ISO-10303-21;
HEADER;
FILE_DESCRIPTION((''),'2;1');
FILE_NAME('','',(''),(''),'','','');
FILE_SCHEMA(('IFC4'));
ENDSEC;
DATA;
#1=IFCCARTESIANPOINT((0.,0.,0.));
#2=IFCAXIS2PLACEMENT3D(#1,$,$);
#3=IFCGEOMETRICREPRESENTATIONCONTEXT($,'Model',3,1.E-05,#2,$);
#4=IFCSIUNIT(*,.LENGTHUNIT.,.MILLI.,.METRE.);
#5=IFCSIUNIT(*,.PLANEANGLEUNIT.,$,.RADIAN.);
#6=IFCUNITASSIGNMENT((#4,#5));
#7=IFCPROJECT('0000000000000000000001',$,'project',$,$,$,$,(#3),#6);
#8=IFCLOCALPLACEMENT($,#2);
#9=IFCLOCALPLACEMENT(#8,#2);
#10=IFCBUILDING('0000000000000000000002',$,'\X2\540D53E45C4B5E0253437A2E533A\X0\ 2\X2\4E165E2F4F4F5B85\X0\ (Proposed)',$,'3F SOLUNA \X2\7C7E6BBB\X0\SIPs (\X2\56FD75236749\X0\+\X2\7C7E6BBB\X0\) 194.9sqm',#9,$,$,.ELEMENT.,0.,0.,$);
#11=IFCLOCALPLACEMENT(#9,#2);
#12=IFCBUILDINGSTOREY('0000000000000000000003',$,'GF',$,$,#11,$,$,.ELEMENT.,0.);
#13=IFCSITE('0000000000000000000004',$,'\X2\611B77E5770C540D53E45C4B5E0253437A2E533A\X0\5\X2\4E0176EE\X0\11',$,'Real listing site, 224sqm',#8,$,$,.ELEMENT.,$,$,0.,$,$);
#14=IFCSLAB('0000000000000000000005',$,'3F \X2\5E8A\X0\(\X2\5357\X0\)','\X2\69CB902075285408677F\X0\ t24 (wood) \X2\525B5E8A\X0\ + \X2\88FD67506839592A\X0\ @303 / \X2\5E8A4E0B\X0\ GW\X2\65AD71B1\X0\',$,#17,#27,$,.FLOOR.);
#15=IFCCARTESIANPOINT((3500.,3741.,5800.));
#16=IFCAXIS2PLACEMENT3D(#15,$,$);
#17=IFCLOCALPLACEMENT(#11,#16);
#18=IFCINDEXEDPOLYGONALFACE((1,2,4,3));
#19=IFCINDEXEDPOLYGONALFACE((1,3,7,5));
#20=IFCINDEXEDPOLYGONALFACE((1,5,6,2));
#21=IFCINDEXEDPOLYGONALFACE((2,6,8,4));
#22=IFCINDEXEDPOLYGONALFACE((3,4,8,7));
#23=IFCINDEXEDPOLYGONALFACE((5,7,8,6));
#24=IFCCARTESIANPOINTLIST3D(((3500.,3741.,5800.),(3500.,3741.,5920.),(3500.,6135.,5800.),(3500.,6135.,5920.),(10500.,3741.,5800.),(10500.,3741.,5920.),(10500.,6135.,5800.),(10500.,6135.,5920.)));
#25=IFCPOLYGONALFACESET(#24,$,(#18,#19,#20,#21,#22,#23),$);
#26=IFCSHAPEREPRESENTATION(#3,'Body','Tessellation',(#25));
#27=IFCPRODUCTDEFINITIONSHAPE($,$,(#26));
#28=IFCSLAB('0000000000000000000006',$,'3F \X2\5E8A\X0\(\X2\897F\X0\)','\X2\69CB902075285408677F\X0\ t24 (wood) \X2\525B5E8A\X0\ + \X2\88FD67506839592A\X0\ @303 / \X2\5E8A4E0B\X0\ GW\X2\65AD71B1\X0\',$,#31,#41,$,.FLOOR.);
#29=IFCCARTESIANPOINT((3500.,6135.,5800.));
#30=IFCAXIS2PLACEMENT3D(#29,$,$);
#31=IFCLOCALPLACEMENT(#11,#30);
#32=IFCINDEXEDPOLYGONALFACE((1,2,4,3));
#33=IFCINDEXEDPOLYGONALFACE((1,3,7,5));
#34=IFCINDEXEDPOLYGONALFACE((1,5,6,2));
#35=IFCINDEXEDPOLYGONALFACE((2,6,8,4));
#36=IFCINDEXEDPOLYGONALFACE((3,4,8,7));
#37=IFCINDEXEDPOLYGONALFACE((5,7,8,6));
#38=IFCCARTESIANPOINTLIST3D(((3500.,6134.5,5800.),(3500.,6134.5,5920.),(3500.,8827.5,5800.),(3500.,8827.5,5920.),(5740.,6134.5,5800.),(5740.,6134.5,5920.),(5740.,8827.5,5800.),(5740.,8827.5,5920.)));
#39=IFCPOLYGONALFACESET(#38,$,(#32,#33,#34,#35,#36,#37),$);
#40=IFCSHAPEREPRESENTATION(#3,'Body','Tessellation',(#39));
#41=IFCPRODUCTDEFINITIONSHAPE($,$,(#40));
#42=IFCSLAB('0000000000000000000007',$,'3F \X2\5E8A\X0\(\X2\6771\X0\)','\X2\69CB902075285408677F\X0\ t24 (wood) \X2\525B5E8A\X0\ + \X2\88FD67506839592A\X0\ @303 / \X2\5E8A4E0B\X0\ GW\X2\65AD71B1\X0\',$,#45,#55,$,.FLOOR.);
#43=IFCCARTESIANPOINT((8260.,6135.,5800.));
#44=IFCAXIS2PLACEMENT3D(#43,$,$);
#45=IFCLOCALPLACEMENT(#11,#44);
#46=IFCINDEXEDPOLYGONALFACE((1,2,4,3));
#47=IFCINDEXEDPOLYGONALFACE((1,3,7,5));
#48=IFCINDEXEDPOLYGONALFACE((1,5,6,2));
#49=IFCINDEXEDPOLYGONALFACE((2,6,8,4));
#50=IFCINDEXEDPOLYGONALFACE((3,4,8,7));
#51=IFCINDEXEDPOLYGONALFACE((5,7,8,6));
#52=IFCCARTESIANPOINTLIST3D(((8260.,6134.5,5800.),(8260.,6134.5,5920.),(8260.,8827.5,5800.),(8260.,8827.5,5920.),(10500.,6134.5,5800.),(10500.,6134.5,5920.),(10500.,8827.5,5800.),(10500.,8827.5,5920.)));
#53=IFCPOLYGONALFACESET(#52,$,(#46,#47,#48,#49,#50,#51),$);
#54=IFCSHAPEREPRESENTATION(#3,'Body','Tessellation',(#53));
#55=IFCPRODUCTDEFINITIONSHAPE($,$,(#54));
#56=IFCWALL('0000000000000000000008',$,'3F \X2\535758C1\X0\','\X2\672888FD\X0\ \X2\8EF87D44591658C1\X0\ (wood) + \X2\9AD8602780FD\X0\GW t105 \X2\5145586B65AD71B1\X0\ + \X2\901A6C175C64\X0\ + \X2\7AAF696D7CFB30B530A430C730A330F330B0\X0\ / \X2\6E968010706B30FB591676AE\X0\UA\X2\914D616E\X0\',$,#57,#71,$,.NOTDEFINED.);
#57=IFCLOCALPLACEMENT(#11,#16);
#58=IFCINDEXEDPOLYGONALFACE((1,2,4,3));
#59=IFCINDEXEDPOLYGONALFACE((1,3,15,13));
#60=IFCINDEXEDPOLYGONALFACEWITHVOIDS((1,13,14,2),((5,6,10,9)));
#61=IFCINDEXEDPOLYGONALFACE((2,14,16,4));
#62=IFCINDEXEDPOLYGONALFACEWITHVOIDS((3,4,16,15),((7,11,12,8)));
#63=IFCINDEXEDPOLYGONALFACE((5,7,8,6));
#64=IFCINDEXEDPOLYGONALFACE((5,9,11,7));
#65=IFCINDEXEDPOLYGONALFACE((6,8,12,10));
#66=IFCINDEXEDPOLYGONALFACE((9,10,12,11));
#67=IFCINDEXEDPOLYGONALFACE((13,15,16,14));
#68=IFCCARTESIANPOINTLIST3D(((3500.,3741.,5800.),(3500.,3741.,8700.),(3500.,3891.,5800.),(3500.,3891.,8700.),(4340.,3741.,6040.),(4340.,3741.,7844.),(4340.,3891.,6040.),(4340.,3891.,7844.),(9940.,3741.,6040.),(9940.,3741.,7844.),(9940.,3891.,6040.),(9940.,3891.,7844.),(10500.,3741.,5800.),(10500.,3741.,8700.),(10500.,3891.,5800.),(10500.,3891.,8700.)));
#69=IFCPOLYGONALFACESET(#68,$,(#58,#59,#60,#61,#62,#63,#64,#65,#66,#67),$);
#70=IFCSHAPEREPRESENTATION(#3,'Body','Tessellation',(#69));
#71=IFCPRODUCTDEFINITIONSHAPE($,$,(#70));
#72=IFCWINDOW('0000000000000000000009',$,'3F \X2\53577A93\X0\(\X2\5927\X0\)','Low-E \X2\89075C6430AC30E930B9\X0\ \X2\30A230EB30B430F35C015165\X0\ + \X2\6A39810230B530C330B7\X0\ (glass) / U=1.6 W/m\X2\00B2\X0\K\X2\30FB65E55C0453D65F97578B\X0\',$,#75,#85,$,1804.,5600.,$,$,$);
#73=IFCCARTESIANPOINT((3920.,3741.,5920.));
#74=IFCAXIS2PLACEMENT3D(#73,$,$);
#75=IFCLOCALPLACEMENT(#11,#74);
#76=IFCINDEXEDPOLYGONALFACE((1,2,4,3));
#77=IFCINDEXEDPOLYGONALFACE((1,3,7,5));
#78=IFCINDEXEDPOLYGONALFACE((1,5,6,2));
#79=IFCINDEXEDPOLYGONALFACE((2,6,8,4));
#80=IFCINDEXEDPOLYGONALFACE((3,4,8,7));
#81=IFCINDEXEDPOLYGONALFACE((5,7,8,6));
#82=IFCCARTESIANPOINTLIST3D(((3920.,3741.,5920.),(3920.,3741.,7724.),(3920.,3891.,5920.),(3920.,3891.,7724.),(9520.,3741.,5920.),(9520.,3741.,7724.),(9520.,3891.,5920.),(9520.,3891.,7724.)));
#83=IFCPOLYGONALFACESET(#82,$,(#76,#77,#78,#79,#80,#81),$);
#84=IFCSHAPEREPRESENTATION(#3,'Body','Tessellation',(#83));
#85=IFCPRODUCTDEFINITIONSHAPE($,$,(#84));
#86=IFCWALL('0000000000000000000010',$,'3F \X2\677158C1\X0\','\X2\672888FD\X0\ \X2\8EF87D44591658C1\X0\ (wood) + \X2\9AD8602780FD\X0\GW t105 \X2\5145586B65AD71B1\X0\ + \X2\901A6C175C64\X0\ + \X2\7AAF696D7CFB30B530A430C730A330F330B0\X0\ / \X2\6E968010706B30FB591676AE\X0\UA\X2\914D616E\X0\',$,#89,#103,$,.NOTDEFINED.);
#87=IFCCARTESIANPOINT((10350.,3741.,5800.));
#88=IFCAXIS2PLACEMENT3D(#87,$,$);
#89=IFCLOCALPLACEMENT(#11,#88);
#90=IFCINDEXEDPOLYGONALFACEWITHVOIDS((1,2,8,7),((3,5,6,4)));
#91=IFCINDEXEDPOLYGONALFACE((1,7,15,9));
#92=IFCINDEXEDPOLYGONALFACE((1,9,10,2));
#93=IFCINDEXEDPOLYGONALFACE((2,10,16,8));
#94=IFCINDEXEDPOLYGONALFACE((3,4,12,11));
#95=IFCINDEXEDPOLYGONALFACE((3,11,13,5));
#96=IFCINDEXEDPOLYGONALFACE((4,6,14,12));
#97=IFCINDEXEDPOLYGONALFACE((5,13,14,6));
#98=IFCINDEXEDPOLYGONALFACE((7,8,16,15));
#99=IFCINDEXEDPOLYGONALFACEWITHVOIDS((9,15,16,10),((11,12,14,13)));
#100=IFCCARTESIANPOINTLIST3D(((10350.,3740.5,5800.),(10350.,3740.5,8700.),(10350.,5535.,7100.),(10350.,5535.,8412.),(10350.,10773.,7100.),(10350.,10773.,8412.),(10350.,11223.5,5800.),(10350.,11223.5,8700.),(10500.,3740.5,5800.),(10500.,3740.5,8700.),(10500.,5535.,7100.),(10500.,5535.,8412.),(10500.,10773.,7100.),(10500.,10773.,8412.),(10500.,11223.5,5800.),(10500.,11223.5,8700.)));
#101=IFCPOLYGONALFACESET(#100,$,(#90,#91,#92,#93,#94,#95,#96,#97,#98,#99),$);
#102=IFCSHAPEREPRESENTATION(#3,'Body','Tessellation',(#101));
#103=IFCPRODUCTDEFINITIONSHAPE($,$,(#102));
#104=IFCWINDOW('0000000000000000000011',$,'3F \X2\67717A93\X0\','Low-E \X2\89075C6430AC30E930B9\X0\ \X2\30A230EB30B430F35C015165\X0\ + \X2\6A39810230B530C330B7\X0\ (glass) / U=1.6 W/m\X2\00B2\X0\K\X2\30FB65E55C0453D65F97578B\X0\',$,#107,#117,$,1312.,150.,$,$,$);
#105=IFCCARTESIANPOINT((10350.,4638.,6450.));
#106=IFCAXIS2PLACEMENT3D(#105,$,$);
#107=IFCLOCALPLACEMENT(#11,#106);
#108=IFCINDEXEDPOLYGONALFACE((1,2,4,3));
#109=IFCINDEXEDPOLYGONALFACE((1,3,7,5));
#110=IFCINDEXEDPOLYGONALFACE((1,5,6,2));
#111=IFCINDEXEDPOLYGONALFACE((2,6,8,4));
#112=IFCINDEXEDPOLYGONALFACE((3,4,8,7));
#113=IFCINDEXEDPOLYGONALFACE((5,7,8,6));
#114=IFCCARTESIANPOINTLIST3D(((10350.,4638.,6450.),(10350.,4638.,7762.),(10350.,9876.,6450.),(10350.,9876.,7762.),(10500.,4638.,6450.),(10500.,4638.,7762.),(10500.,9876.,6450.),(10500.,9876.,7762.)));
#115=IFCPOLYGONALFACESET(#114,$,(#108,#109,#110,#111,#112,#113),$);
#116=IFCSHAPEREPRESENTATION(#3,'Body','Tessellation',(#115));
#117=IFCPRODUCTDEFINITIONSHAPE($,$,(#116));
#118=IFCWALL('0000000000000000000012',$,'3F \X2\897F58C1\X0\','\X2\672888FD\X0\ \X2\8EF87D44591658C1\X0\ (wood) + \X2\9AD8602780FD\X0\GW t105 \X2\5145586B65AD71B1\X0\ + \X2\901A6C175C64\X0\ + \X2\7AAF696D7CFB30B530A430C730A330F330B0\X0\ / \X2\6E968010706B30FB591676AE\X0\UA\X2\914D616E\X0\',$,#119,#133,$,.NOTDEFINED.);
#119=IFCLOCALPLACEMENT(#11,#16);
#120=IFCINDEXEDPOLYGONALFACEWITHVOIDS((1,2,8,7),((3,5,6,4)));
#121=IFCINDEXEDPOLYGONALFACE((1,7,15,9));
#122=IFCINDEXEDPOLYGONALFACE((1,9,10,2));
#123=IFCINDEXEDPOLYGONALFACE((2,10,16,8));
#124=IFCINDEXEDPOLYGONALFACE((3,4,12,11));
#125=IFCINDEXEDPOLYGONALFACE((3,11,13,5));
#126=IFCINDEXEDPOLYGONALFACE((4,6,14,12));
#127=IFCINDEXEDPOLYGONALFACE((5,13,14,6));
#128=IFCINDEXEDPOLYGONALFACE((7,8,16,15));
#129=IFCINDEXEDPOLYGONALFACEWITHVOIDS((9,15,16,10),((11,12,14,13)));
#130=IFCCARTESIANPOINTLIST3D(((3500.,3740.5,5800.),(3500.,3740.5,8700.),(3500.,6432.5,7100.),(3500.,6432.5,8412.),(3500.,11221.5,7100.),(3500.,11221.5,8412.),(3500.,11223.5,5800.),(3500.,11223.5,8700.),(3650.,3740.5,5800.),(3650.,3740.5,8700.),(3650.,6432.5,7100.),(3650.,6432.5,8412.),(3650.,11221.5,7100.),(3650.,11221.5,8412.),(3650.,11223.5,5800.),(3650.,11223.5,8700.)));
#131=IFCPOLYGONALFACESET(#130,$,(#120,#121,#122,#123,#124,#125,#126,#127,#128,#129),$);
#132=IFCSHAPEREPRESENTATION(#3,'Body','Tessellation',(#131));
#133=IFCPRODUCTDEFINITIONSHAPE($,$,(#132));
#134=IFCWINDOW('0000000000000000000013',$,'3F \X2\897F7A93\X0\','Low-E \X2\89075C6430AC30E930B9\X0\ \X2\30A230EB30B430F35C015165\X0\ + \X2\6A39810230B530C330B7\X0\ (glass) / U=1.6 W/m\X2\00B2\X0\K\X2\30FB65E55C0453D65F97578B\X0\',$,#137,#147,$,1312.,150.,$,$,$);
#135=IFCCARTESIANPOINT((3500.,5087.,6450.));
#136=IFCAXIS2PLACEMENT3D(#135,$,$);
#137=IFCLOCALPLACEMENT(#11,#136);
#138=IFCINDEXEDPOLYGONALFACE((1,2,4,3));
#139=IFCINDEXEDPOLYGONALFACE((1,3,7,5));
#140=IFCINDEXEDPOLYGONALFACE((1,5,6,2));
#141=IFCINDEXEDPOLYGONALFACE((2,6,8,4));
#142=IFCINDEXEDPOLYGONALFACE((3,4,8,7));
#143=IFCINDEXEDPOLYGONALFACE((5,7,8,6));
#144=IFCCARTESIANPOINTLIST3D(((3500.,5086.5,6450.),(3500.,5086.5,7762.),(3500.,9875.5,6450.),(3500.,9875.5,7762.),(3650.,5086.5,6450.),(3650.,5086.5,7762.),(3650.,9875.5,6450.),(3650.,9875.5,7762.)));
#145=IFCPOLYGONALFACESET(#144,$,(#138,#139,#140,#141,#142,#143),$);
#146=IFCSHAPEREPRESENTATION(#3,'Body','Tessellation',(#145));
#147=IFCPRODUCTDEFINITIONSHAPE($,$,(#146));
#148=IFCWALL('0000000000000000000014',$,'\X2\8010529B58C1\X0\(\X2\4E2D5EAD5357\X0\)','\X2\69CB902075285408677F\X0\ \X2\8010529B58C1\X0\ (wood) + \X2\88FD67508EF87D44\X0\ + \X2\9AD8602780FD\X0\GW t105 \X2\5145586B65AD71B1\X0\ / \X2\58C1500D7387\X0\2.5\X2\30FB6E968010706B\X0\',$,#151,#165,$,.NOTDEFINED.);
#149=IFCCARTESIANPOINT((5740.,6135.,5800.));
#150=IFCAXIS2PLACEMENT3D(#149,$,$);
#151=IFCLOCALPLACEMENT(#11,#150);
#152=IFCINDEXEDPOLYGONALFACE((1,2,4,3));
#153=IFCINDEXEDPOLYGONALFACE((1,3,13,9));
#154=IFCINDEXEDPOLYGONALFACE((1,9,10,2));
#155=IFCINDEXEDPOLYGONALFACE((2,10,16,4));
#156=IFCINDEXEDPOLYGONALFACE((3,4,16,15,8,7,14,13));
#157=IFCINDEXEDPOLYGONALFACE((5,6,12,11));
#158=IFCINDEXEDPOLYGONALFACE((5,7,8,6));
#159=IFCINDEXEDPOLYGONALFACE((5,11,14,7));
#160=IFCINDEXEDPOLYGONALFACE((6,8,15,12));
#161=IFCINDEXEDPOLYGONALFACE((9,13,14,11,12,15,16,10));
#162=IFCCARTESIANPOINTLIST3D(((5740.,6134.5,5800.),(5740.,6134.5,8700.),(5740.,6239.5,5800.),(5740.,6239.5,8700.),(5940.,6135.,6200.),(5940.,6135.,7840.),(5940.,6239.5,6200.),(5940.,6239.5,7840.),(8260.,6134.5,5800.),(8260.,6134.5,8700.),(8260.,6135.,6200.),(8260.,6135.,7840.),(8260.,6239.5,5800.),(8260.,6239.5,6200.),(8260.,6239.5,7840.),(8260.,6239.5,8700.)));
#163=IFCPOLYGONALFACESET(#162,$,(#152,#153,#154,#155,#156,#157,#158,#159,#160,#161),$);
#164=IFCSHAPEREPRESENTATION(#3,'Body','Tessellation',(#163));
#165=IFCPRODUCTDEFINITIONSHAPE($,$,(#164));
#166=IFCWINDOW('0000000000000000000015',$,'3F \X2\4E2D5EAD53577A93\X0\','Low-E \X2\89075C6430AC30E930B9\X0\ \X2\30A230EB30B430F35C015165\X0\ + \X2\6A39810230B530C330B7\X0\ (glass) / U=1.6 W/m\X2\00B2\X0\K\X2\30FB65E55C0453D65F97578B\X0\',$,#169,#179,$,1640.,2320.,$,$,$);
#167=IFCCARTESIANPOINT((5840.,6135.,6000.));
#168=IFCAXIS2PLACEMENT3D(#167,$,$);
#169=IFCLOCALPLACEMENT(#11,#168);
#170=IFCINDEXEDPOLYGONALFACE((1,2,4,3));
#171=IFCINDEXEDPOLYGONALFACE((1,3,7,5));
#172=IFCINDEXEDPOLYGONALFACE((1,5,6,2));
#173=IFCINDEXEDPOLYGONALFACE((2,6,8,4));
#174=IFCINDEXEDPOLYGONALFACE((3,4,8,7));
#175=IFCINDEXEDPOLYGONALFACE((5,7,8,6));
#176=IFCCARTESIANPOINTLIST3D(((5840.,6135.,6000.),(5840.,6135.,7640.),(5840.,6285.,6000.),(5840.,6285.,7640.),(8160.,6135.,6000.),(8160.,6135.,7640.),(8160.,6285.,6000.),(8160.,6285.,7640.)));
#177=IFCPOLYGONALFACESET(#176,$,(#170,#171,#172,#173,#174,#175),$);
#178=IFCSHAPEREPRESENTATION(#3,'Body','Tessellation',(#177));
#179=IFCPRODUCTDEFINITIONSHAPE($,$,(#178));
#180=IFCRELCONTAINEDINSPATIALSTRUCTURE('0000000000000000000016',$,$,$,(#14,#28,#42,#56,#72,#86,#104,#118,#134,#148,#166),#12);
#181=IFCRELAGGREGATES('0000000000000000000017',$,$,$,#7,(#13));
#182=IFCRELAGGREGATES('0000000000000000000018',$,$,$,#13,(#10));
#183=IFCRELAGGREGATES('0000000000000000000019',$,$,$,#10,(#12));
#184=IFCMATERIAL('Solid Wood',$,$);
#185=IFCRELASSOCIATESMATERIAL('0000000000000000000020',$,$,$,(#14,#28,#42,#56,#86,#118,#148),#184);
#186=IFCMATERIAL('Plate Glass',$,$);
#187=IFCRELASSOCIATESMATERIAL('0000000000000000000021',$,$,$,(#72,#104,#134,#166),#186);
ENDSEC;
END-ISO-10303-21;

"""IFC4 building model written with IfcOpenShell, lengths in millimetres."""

from ifc_helpers import new_model, si_unit, frame, frame_2d, origin, place, context, project, spatial, rectangle, extrude, material, element, fill, save


model = new_model("IFC4")

# Units and contexts
model_context = context("Model", 3, precision=1e-05, world=origin())
ifc_project = project(units=[si_unit("LENGTHUNIT", "METRE", prefix="MILLI"), si_unit("PLANEANGLEUNIT", "RADIAN")], contexts=[model_context])

# Site, building, storey
site_placement = place(None, origin())
site = spatial("IfcSite", under=ifc_project, at=site_placement, Name="愛知県名古屋市千種区5丁目11", ObjectType="Real listing site, 224sqm", CompositionType="ELEMENT", RefElevation=0.0)
building_placement = place(site_placement, origin())
building = spatial("IfcBuilding", under=site, at=building_placement, Name="名古屋市千種区 2世帯住宅 (Proposed)", ObjectType="3F SOLUNA 籾殻SIPs (国産杉+籾殻) 194.9sqm", CompositionType="ELEMENT", ElevationOfRefHeight=0.0, ElevationOfTerrain=0.0)
storey_placement = place(building_placement, origin())
storey = spatial("IfcBuildingStorey", under=building, at=storey_placement, Name="GF", CompositionType="ELEMENT", Elevation=0.0)

# Slabs
ifc_material_1 = material(Name="Solid Wood")
slab_1_placement = place(storey_placement, frame((3500.0, 3741.0, 5800.0)))
element("IfcSlab", 1, at=slab_1_placement, inside=storey, material=ifc_material_1, Name="3F 床(南)", Description="構造用合板 t24 (wood) 剛床 + 製材根太 @303 / 床下 GW断熱", PredefinedType="FLOOR", context=model_context, shape_type="SweptSolid", body=[
    extrude(rectangle(XDim=7000.0, YDim=2394.0, at=frame_2d((3500.0, 1197.0))), frame((3500.0, 3741.0, 5800.0)), (0.0, 0.0, 1.0), 120.0),
])
slab_2_placement = place(storey_placement, frame((3500.0, 6135.0, 5800.0)))
element("IfcSlab", 2, at=slab_2_placement, inside=storey, material=ifc_material_1, Name="3F 床(西)", Description="構造用合板 t24 (wood) 剛床 + 製材根太 @303 / 床下 GW断熱", PredefinedType="FLOOR", context=model_context, shape_type="SweptSolid", body=[
    extrude(rectangle(XDim=2240.0, YDim=2693.0, at=frame_2d((1120.0, 1346.0))), frame((3500.0, 6135.0, 5800.0)), (0.0, 0.0, 1.0), 120.0),
])
slab_3_placement = place(storey_placement, frame((8260.0, 6135.0, 5800.0)))
element("IfcSlab", 3, at=slab_3_placement, inside=storey, material=ifc_material_1, Name="3F 床(東)", Description="構造用合板 t24 (wood) 剛床 + 製材根太 @303 / 床下 GW断熱", PredefinedType="FLOOR", context=model_context, shape_type="SweptSolid", body=[
    extrude(rectangle(XDim=2240.0, YDim=2693.0, at=frame_2d((1120.0, 1346.0))), frame((8260.0, 6135.0, 5800.0)), (0.0, 0.0, 1.0), 120.0),
])

# Walls, openings, windows
wall_1_placement = place(storey_placement, frame((3500.0, 3741.0, 5800.0)))
wall_1 = element("IfcWall", 4, at=wall_1_placement, inside=storey, material=ifc_material_1, Name="3F 南壁", Description="木製 軸組外壁 (wood) + 高性能GW t105 充填断熱 + 通気層 + 窯業系サイディング / 準耐火・外皮UA配慮", PredefinedType="NOTDEFINED", context=model_context, shape_type="SweptSolid", body=[
    extrude(rectangle(XDim=7000.0, YDim=150.0, at=frame_2d((3500.0, 75.0))), frame((3500.0, 3741.0, 5800.0)), (0.0, 0.0, 1.0), 2900.0),
])
opening_1_placement = place(storey_placement, frame((3920.0, 3741.0, 5920.0)))
opening_1 = element("IfcOpeningElement", 5, at=opening_1_placement, cuts=wall_1, PredefinedType="NOTDEFINED", context=model_context, shape_type="SweptSolid", body=[
    extrude(rectangle(XDim=5600.0, YDim=150.0, at=frame_2d((2800.0, 75.0))), frame((3920.0, 3741.0, 5920.0)), (0.0, 0.0, 1.0), 1804.0),
])
ifc_material_2 = material(Name="Plate Glass")
window_1_placement = place(storey_placement, frame((3920.0, 3741.0, 5920.0)))
window_1 = element("IfcWindow", 6, at=window_1_placement, inside=storey, material=ifc_material_2, Name="3F 南窓(大)", Description="Low-E 複層ガラス アルゴン封入 + 樹脂サッシ (glass) / U=1.6 W/m²K・日射取得型", OverallHeight=1804.0, OverallWidth=5600.0, context=model_context, shape_type="SweptSolid", body=[
    extrude(rectangle(XDim=5600.0, YDim=150.0, at=frame_2d((2800.0, 75.0))), frame((3920.0, 3741.0, 5920.0)), (0.0, 0.0, 1.0), 1804.0),
])
fill(opening_1, window_1)
wall_2_placement = place(storey_placement, frame((10350.0, 3741.0, 5800.0)))
wall_2 = element("IfcWall", 7, at=wall_2_placement, inside=storey, material=ifc_material_1, Name="3F 東壁", Description="木製 軸組外壁 (wood) + 高性能GW t105 充填断熱 + 通気層 + 窯業系サイディング / 準耐火・外皮UA配慮", PredefinedType="NOTDEFINED", context=model_context, shape_type="SweptSolid", body=[
    extrude(rectangle(XDim=150.0, YDim=7483.0, at=frame_2d((75.0, 3741.0))), frame((10350.0, 3741.0, 5800.0)), (0.0, 0.0, 1.0), 2900.0),
])
opening_2_placement = place(storey_placement, frame((10350.0, 4638.0, 6450.0)))
opening_2 = element("IfcOpeningElement", 8, at=opening_2_placement, cuts=wall_2, PredefinedType="NOTDEFINED", context=model_context, shape_type="SweptSolid", body=[
    extrude(rectangle(XDim=150.0, YDim=5238.0, at=frame_2d((75.0, 2619.0))), frame((10350.0, 4638.0, 6450.0)), (0.0, 0.0, 1.0), 1312.0),
])
window_2_placement = place(storey_placement, frame((10350.0, 4638.0, 6450.0)))
window_2 = element("IfcWindow", 9, at=window_2_placement, inside=storey, material=ifc_material_2, Name="3F 東窓", Description="Low-E 複層ガラス アルゴン封入 + 樹脂サッシ (glass) / U=1.6 W/m²K・日射取得型", OverallHeight=1312.0, OverallWidth=150.0, context=model_context, shape_type="SweptSolid", body=[
    extrude(rectangle(XDim=150.0, YDim=5238.0, at=frame_2d((75.0, 2619.0))), frame((10350.0, 4638.0, 6450.0)), (0.0, 0.0, 1.0), 1312.0),
])
fill(opening_2, window_2)
wall_3_placement = place(storey_placement, frame((3500.0, 3741.0, 5800.0)))
wall_3 = element("IfcWall", 10, at=wall_3_placement, inside=storey, material=ifc_material_1, Name="3F 西壁", Description="木製 軸組外壁 (wood) + 高性能GW t105 充填断熱 + 通気層 + 窯業系サイディング / 準耐火・外皮UA配慮", PredefinedType="NOTDEFINED", context=model_context, shape_type="SweptSolid", body=[
    extrude(rectangle(XDim=150.0, YDim=7483.0, at=frame_2d((75.0, 3741.0))), frame((3500.0, 3741.0, 5800.0)), (0.0, 0.0, 1.0), 2900.0),
])
opening_3_placement = place(storey_placement, frame((3500.0, 5087.0, 6450.0)))
opening_3 = element("IfcOpeningElement", 11, at=opening_3_placement, cuts=wall_3, PredefinedType="NOTDEFINED", context=model_context, shape_type="SweptSolid", body=[
    extrude(rectangle(XDim=150.0, YDim=4789.0, at=frame_2d((75.0, 2394.0))), frame((3500.0, 5087.0, 6450.0)), (0.0, 0.0, 1.0), 1312.0),
])
window_3_placement = place(storey_placement, frame((3500.0, 5087.0, 6450.0)))
window_3 = element("IfcWindow", 12, at=window_3_placement, inside=storey, material=ifc_material_2, Name="3F 西窓", Description="Low-E 複層ガラス アルゴン封入 + 樹脂サッシ (glass) / U=1.6 W/m²K・日射取得型", OverallHeight=1312.0, OverallWidth=150.0, context=model_context, shape_type="SweptSolid", body=[
    extrude(rectangle(XDim=150.0, YDim=4789.0, at=frame_2d((75.0, 2394.0))), frame((3500.0, 5087.0, 6450.0)), (0.0, 0.0, 1.0), 1312.0),
])
fill(opening_3, window_3)
wall_4_placement = place(storey_placement, frame((5740.0, 6135.0, 5800.0)))
wall_4 = element("IfcWall", 13, at=wall_4_placement, inside=storey, material=ifc_material_1, Name="耐力壁(中庭南)", Description="構造用合板 耐力壁 (wood) + 製材軸組 + 高性能GW t105 充填断熱 / 壁倍率2.5・準耐火", PredefinedType="NOTDEFINED", context=model_context, shape_type="SweptSolid", body=[
    extrude(rectangle(XDim=2520.0, YDim=105.0, at=frame_2d((1260.0, 52.0))), frame((5740.0, 6135.0, 5800.0)), (0.0, 0.0, 1.0), 2900.0),
])
opening_4_placement = place(storey_placement, frame((5840.0, 6135.0, 6000.0)))
opening_4 = element("IfcOpeningElement", 14, at=opening_4_placement, cuts=wall_4, PredefinedType="NOTDEFINED", context=model_context, shape_type="SweptSolid", body=[
    extrude(rectangle(XDim=2320.0, YDim=150.0, at=frame_2d((1160.0, 75.0))), frame((5840.0, 6135.0, 6000.0)), (0.0, 0.0, 1.0), 1640.0),
])
window_4_placement = place(storey_placement, frame((5840.0, 6135.0, 6000.0)))
window_4 = element("IfcWindow", 15, at=window_4_placement, inside=storey, material=ifc_material_2, Name="3F 中庭南窓", Description="Low-E 複層ガラス アルゴン封入 + 樹脂サッシ (glass) / U=1.6 W/m²K・日射取得型", OverallHeight=1640.0, OverallWidth=2320.0, context=model_context, shape_type="SweptSolid", body=[
    extrude(rectangle(XDim=2320.0, YDim=150.0, at=frame_2d((1160.0, 75.0))), frame((5840.0, 6135.0, 6000.0)), (0.0, 0.0, 1.0), 1640.0),
])
fill(opening_4, window_4)

save(model, "model.ifc")
